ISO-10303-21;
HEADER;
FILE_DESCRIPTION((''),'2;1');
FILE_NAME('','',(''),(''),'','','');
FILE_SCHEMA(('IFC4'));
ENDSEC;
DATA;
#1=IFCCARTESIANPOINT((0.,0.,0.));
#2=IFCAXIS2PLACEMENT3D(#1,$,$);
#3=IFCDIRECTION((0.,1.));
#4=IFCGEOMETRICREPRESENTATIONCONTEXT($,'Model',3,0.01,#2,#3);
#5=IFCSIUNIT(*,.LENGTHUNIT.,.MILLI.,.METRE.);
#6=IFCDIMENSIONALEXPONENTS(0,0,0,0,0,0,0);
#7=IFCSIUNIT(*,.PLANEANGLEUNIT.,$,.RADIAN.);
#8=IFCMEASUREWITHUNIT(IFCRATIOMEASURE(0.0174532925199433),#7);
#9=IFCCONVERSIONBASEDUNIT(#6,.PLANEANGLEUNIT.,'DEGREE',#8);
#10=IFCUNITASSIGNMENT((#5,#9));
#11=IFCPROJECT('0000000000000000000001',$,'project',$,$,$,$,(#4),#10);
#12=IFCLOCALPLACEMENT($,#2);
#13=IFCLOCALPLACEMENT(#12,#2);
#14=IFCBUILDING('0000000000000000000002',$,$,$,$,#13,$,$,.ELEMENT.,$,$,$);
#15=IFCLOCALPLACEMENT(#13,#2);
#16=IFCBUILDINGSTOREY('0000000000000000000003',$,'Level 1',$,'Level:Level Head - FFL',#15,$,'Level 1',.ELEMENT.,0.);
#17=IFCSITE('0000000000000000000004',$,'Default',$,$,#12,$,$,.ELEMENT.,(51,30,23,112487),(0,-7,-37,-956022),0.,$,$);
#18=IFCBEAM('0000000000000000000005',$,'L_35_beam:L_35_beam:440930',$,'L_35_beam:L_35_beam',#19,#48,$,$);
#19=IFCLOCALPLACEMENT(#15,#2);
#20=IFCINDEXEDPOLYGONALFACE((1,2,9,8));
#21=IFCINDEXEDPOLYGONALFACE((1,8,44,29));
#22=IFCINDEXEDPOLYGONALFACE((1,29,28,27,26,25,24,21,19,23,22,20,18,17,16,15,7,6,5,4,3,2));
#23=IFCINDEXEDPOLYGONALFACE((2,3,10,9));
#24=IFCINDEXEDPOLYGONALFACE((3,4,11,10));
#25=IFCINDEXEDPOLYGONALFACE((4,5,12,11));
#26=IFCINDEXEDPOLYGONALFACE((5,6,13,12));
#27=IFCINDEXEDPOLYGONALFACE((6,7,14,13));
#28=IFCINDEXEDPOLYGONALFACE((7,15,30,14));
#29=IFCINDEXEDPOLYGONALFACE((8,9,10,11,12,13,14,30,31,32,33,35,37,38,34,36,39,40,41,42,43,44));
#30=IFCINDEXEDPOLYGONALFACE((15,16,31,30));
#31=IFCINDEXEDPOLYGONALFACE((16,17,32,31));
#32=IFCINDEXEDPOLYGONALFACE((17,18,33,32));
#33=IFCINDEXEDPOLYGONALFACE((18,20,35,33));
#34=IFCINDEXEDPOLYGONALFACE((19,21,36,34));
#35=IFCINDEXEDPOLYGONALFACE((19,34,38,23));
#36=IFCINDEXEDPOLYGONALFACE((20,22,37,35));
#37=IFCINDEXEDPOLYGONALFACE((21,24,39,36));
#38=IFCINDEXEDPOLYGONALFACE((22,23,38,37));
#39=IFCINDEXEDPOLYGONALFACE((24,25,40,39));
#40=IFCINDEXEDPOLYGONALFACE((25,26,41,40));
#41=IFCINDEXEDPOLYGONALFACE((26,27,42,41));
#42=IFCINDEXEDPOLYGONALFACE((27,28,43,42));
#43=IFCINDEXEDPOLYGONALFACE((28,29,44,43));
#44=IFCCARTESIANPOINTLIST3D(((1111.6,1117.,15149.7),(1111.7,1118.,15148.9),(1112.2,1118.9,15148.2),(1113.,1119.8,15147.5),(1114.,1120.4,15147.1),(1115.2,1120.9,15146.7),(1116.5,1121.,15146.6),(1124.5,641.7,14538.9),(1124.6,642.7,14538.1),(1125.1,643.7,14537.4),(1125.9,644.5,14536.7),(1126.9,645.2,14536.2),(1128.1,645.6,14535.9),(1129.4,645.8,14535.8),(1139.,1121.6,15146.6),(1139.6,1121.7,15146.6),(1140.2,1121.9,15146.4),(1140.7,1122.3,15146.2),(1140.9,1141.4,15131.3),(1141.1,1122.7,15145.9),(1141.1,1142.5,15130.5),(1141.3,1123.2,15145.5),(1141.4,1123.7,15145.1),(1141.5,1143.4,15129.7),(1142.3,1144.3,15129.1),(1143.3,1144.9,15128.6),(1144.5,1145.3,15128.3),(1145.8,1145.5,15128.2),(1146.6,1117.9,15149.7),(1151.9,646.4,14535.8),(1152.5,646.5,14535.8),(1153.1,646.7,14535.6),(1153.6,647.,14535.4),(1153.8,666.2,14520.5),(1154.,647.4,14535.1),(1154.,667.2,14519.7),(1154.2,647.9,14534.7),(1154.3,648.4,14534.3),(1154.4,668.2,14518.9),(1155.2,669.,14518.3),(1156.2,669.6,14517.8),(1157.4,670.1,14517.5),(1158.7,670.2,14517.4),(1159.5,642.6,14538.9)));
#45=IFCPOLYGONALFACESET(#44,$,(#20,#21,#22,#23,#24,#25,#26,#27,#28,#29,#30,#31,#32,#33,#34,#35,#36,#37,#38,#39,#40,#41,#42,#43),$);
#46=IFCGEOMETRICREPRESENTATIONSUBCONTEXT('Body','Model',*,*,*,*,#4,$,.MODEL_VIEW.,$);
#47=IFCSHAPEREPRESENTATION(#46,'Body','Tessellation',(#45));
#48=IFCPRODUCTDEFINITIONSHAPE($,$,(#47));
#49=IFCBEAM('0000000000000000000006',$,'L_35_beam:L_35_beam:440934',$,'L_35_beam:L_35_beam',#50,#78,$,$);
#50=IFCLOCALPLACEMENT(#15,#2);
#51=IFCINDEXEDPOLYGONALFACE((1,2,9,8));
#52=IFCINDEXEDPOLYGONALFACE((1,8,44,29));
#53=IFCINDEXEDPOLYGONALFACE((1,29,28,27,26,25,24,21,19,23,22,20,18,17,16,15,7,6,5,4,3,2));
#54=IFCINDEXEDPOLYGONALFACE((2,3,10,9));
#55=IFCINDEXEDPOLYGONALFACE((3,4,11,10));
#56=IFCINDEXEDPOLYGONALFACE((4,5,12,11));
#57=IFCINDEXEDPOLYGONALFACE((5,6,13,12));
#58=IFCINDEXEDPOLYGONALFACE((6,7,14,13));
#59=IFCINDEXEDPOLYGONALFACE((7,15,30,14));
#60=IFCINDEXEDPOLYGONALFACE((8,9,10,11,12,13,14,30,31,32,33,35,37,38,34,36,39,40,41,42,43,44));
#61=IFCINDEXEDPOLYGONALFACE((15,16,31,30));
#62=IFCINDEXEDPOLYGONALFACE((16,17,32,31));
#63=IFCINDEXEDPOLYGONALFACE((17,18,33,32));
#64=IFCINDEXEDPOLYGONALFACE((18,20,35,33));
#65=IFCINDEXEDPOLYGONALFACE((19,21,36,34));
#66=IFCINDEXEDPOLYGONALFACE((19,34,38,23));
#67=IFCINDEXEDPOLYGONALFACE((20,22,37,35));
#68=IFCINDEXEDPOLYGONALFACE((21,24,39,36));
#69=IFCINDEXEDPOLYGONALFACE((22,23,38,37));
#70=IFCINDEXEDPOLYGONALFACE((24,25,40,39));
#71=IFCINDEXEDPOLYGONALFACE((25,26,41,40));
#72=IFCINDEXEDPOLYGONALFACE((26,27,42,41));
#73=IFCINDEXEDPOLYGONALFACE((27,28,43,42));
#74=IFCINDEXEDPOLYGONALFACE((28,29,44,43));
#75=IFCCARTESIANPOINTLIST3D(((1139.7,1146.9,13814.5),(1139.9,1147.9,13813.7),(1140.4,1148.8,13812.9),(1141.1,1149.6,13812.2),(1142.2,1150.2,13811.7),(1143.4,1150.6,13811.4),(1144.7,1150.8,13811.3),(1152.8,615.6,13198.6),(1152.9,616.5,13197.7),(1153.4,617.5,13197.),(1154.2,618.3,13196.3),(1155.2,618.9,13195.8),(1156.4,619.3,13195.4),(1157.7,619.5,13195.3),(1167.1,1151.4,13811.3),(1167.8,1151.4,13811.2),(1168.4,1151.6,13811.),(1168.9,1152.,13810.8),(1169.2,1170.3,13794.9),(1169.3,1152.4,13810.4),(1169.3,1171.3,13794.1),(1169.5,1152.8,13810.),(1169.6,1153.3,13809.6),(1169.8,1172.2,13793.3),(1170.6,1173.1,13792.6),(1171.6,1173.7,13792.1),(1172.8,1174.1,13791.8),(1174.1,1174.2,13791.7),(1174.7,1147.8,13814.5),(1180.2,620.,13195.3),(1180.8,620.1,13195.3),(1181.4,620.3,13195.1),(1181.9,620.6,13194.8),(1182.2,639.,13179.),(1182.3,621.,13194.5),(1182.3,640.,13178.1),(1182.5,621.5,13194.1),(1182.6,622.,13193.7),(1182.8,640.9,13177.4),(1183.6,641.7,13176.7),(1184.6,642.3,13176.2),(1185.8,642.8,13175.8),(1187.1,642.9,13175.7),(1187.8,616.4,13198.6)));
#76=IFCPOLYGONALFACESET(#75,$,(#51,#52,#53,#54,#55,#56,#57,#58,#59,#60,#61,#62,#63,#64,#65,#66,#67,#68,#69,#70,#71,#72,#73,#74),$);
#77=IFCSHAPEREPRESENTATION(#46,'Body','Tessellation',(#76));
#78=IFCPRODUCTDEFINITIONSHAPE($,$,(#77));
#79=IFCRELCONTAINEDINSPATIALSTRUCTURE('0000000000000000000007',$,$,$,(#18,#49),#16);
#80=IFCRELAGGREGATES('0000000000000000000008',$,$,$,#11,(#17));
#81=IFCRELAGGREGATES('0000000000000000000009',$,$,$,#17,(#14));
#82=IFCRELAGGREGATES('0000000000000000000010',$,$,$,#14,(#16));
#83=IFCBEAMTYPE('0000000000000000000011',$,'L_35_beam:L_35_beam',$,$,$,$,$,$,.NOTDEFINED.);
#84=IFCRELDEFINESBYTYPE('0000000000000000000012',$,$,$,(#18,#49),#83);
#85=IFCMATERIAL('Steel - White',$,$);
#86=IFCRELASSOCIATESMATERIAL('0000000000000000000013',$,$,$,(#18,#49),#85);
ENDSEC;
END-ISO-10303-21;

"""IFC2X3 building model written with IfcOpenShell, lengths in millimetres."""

from ifc_helpers import new_model, entity, si_unit, converted_unit, direction, frame, frame_2d, origin, place, context, subcontext, project, spatial, polyline, circle_curve, parameter, trimmed, segment, composite_curve, outline, extrude, material, type_object, element, save


model = new_model("IFC2X3")

# Units and contexts
model_context = context("Model", 3, precision=0.01, world=origin(), true_north=direction((0.0, 1.0)))
body_context = subcontext(model_context, "Body", "Model", "MODEL_VIEW")
ifc_project = project(units=[si_unit("LENGTHUNIT", "METRE", prefix="MILLI"), converted_unit("PLANEANGLEUNIT", "DEGREE", entity("IfcRatioMeasure", 0.0174532925199433), si_unit("PLANEANGLEUNIT", "RADIAN"), dimensions=[0, 0, 0, 0, 0, 0, 0])], contexts=[model_context])

# Site, building, storey
site_placement = place(None, origin())
site = spatial("IfcSite", under=ifc_project, at=site_placement, Name="Default", CompositionType="ELEMENT", RefLatitude=(51, 30, 23, 112487), RefLongitude=(0, -7, -37, -956022), RefElevation=0.0)
building_placement = place(site_placement, origin())
building = spatial("IfcBuilding", under=site, at=building_placement, CompositionType="ELEMENT")
storey_placement = place(building_placement, origin())
storey = spatial("IfcBuildingStorey", under=building, at=storey_placement, Name="Level 1", ObjectType="Level:Level Head - FFL", LongName="Level 1", CompositionType="ELEMENT", Elevation=0.0)

# Beams
ifc_material_1 = material(Name="Steel - White")
beam_type_1 = type_object("IfcBeamType", Name="L_35_beam:L_35_beam", PredefinedType="NOTDEFINED")
beam_1_placement = place(storey_placement, frame((1153.6, 1153.5, 15166.7), z_axis=(0.999861, 0.010239, 0.013159), x_axis=(0.016674, -0.614019, -0.789115)))
element("IfcBeam", 1, at=beam_1_placement, inside=storey, type_object=beam_type_1, material=ifc_material_1, Name="L_35_beam:L_35_beam:440930", ObjectType="L_35_beam:L_35_beam", context=body_context, shape_type="SweptSolid", body=[
    extrude(outline(composite_curve([segment(polyline([(-23.2, -11.8), (11.8, -11.8)]), True, "CONTINUOUS"), segment(polyline([(11.8, -11.8), (11.8, 23.2)]), True, "CONTINUOUS"), segment(trimmed(circle_curve(frame_2d((11.8, 18.2), x_axis=(0.0, 1.0)), 5.0), [parameter(0.0)], [parameter(90.0)], True, "PARAMETER"), True, "CONTINUOUS"), segment(polyline([(6.8, 18.2), (6.8, -4.3)]), True, "CONTINUOUS"), segment(trimmed(circle_curve(frame_2d((4.3, -4.3), x_axis=(1.0, 0.0)), 2.5), [parameter(270.0)], [parameter(0.0)], True, "PARAMETER"), False, "CONTINUOUS"), segment(polyline([(4.3, -6.8), (-18.2, -6.8)]), True, "CONTINUOUS"), segment(trimmed(circle_curve(frame_2d((-18.2, -11.8), x_axis=(0.0, 1.0)), 5.0), [parameter(0.0)], [parameter(90.0)], True, "PARAMETER"), True, "CONTINUOUS")], self_intersect=False)), frame((35.2, -6.1, -19.7), z_axis=(1.0, 0.0, 0.0), x_axis=(0.0, -0.99977, 0.021423)), (0.0, 0.0, 1.0), 774.0),
])
beam_2_placement = place(storey_placement, frame((1181.9, 1181.8, 13827.0), z_axis=(0.999872, 0.010449, 0.012113), x_axis=(0.015997, -0.653107, -0.757096)))
element("IfcBeam", 2, at=beam_2_placement, inside=storey, type_object=beam_type_1, material=ifc_material_1, Name="L_35_beam:L_35_beam:440934", ObjectType="L_35_beam:L_35_beam", context=body_context, shape_type="SweptSolid", body=[
    extrude(outline(composite_curve([segment(polyline([(-23.2, -11.8), (11.8, -11.8)]), True, "CONTINUOUS"), segment(polyline([(11.8, -11.8), (11.8, 23.2)]), True, "CONTINUOUS"), segment(trimmed(circle_curve(frame_2d((11.8, 18.2), x_axis=(0.0, 1.0)), 5.0), [parameter(0.0)], [parameter(90.0)], True, "PARAMETER"), True, "CONTINUOUS"), segment(polyline([(6.8, 18.2), (6.8, -4.3)]), True, "CONTINUOUS"), segment(trimmed(circle_curve(frame_2d((4.3, -4.3), x_axis=(1.0, 0.0)), 2.5), [parameter(270.0)], [parameter(0.0)], True, "PARAMETER"), False, "CONTINUOUS"), segment(polyline([(4.3, -6.8), (-18.2, -6.8)]), True, "CONTINUOUS"), segment(trimmed(circle_curve(frame_2d((-18.2, -11.8), x_axis=(0.0, 1.0)), 5.0), [parameter(0.0)], [parameter(90.0)], True, "PARAMETER"), True, "CONTINUOUS")], self_intersect=False)), frame((31.6, -6.1, -19.7), z_axis=(1.0, 0.0, 0.0), x_axis=(0.0, -0.999828, 0.018541)), (0.0, 0.0, 1.0), 813.5),
])

save(model, "model.ifc")
